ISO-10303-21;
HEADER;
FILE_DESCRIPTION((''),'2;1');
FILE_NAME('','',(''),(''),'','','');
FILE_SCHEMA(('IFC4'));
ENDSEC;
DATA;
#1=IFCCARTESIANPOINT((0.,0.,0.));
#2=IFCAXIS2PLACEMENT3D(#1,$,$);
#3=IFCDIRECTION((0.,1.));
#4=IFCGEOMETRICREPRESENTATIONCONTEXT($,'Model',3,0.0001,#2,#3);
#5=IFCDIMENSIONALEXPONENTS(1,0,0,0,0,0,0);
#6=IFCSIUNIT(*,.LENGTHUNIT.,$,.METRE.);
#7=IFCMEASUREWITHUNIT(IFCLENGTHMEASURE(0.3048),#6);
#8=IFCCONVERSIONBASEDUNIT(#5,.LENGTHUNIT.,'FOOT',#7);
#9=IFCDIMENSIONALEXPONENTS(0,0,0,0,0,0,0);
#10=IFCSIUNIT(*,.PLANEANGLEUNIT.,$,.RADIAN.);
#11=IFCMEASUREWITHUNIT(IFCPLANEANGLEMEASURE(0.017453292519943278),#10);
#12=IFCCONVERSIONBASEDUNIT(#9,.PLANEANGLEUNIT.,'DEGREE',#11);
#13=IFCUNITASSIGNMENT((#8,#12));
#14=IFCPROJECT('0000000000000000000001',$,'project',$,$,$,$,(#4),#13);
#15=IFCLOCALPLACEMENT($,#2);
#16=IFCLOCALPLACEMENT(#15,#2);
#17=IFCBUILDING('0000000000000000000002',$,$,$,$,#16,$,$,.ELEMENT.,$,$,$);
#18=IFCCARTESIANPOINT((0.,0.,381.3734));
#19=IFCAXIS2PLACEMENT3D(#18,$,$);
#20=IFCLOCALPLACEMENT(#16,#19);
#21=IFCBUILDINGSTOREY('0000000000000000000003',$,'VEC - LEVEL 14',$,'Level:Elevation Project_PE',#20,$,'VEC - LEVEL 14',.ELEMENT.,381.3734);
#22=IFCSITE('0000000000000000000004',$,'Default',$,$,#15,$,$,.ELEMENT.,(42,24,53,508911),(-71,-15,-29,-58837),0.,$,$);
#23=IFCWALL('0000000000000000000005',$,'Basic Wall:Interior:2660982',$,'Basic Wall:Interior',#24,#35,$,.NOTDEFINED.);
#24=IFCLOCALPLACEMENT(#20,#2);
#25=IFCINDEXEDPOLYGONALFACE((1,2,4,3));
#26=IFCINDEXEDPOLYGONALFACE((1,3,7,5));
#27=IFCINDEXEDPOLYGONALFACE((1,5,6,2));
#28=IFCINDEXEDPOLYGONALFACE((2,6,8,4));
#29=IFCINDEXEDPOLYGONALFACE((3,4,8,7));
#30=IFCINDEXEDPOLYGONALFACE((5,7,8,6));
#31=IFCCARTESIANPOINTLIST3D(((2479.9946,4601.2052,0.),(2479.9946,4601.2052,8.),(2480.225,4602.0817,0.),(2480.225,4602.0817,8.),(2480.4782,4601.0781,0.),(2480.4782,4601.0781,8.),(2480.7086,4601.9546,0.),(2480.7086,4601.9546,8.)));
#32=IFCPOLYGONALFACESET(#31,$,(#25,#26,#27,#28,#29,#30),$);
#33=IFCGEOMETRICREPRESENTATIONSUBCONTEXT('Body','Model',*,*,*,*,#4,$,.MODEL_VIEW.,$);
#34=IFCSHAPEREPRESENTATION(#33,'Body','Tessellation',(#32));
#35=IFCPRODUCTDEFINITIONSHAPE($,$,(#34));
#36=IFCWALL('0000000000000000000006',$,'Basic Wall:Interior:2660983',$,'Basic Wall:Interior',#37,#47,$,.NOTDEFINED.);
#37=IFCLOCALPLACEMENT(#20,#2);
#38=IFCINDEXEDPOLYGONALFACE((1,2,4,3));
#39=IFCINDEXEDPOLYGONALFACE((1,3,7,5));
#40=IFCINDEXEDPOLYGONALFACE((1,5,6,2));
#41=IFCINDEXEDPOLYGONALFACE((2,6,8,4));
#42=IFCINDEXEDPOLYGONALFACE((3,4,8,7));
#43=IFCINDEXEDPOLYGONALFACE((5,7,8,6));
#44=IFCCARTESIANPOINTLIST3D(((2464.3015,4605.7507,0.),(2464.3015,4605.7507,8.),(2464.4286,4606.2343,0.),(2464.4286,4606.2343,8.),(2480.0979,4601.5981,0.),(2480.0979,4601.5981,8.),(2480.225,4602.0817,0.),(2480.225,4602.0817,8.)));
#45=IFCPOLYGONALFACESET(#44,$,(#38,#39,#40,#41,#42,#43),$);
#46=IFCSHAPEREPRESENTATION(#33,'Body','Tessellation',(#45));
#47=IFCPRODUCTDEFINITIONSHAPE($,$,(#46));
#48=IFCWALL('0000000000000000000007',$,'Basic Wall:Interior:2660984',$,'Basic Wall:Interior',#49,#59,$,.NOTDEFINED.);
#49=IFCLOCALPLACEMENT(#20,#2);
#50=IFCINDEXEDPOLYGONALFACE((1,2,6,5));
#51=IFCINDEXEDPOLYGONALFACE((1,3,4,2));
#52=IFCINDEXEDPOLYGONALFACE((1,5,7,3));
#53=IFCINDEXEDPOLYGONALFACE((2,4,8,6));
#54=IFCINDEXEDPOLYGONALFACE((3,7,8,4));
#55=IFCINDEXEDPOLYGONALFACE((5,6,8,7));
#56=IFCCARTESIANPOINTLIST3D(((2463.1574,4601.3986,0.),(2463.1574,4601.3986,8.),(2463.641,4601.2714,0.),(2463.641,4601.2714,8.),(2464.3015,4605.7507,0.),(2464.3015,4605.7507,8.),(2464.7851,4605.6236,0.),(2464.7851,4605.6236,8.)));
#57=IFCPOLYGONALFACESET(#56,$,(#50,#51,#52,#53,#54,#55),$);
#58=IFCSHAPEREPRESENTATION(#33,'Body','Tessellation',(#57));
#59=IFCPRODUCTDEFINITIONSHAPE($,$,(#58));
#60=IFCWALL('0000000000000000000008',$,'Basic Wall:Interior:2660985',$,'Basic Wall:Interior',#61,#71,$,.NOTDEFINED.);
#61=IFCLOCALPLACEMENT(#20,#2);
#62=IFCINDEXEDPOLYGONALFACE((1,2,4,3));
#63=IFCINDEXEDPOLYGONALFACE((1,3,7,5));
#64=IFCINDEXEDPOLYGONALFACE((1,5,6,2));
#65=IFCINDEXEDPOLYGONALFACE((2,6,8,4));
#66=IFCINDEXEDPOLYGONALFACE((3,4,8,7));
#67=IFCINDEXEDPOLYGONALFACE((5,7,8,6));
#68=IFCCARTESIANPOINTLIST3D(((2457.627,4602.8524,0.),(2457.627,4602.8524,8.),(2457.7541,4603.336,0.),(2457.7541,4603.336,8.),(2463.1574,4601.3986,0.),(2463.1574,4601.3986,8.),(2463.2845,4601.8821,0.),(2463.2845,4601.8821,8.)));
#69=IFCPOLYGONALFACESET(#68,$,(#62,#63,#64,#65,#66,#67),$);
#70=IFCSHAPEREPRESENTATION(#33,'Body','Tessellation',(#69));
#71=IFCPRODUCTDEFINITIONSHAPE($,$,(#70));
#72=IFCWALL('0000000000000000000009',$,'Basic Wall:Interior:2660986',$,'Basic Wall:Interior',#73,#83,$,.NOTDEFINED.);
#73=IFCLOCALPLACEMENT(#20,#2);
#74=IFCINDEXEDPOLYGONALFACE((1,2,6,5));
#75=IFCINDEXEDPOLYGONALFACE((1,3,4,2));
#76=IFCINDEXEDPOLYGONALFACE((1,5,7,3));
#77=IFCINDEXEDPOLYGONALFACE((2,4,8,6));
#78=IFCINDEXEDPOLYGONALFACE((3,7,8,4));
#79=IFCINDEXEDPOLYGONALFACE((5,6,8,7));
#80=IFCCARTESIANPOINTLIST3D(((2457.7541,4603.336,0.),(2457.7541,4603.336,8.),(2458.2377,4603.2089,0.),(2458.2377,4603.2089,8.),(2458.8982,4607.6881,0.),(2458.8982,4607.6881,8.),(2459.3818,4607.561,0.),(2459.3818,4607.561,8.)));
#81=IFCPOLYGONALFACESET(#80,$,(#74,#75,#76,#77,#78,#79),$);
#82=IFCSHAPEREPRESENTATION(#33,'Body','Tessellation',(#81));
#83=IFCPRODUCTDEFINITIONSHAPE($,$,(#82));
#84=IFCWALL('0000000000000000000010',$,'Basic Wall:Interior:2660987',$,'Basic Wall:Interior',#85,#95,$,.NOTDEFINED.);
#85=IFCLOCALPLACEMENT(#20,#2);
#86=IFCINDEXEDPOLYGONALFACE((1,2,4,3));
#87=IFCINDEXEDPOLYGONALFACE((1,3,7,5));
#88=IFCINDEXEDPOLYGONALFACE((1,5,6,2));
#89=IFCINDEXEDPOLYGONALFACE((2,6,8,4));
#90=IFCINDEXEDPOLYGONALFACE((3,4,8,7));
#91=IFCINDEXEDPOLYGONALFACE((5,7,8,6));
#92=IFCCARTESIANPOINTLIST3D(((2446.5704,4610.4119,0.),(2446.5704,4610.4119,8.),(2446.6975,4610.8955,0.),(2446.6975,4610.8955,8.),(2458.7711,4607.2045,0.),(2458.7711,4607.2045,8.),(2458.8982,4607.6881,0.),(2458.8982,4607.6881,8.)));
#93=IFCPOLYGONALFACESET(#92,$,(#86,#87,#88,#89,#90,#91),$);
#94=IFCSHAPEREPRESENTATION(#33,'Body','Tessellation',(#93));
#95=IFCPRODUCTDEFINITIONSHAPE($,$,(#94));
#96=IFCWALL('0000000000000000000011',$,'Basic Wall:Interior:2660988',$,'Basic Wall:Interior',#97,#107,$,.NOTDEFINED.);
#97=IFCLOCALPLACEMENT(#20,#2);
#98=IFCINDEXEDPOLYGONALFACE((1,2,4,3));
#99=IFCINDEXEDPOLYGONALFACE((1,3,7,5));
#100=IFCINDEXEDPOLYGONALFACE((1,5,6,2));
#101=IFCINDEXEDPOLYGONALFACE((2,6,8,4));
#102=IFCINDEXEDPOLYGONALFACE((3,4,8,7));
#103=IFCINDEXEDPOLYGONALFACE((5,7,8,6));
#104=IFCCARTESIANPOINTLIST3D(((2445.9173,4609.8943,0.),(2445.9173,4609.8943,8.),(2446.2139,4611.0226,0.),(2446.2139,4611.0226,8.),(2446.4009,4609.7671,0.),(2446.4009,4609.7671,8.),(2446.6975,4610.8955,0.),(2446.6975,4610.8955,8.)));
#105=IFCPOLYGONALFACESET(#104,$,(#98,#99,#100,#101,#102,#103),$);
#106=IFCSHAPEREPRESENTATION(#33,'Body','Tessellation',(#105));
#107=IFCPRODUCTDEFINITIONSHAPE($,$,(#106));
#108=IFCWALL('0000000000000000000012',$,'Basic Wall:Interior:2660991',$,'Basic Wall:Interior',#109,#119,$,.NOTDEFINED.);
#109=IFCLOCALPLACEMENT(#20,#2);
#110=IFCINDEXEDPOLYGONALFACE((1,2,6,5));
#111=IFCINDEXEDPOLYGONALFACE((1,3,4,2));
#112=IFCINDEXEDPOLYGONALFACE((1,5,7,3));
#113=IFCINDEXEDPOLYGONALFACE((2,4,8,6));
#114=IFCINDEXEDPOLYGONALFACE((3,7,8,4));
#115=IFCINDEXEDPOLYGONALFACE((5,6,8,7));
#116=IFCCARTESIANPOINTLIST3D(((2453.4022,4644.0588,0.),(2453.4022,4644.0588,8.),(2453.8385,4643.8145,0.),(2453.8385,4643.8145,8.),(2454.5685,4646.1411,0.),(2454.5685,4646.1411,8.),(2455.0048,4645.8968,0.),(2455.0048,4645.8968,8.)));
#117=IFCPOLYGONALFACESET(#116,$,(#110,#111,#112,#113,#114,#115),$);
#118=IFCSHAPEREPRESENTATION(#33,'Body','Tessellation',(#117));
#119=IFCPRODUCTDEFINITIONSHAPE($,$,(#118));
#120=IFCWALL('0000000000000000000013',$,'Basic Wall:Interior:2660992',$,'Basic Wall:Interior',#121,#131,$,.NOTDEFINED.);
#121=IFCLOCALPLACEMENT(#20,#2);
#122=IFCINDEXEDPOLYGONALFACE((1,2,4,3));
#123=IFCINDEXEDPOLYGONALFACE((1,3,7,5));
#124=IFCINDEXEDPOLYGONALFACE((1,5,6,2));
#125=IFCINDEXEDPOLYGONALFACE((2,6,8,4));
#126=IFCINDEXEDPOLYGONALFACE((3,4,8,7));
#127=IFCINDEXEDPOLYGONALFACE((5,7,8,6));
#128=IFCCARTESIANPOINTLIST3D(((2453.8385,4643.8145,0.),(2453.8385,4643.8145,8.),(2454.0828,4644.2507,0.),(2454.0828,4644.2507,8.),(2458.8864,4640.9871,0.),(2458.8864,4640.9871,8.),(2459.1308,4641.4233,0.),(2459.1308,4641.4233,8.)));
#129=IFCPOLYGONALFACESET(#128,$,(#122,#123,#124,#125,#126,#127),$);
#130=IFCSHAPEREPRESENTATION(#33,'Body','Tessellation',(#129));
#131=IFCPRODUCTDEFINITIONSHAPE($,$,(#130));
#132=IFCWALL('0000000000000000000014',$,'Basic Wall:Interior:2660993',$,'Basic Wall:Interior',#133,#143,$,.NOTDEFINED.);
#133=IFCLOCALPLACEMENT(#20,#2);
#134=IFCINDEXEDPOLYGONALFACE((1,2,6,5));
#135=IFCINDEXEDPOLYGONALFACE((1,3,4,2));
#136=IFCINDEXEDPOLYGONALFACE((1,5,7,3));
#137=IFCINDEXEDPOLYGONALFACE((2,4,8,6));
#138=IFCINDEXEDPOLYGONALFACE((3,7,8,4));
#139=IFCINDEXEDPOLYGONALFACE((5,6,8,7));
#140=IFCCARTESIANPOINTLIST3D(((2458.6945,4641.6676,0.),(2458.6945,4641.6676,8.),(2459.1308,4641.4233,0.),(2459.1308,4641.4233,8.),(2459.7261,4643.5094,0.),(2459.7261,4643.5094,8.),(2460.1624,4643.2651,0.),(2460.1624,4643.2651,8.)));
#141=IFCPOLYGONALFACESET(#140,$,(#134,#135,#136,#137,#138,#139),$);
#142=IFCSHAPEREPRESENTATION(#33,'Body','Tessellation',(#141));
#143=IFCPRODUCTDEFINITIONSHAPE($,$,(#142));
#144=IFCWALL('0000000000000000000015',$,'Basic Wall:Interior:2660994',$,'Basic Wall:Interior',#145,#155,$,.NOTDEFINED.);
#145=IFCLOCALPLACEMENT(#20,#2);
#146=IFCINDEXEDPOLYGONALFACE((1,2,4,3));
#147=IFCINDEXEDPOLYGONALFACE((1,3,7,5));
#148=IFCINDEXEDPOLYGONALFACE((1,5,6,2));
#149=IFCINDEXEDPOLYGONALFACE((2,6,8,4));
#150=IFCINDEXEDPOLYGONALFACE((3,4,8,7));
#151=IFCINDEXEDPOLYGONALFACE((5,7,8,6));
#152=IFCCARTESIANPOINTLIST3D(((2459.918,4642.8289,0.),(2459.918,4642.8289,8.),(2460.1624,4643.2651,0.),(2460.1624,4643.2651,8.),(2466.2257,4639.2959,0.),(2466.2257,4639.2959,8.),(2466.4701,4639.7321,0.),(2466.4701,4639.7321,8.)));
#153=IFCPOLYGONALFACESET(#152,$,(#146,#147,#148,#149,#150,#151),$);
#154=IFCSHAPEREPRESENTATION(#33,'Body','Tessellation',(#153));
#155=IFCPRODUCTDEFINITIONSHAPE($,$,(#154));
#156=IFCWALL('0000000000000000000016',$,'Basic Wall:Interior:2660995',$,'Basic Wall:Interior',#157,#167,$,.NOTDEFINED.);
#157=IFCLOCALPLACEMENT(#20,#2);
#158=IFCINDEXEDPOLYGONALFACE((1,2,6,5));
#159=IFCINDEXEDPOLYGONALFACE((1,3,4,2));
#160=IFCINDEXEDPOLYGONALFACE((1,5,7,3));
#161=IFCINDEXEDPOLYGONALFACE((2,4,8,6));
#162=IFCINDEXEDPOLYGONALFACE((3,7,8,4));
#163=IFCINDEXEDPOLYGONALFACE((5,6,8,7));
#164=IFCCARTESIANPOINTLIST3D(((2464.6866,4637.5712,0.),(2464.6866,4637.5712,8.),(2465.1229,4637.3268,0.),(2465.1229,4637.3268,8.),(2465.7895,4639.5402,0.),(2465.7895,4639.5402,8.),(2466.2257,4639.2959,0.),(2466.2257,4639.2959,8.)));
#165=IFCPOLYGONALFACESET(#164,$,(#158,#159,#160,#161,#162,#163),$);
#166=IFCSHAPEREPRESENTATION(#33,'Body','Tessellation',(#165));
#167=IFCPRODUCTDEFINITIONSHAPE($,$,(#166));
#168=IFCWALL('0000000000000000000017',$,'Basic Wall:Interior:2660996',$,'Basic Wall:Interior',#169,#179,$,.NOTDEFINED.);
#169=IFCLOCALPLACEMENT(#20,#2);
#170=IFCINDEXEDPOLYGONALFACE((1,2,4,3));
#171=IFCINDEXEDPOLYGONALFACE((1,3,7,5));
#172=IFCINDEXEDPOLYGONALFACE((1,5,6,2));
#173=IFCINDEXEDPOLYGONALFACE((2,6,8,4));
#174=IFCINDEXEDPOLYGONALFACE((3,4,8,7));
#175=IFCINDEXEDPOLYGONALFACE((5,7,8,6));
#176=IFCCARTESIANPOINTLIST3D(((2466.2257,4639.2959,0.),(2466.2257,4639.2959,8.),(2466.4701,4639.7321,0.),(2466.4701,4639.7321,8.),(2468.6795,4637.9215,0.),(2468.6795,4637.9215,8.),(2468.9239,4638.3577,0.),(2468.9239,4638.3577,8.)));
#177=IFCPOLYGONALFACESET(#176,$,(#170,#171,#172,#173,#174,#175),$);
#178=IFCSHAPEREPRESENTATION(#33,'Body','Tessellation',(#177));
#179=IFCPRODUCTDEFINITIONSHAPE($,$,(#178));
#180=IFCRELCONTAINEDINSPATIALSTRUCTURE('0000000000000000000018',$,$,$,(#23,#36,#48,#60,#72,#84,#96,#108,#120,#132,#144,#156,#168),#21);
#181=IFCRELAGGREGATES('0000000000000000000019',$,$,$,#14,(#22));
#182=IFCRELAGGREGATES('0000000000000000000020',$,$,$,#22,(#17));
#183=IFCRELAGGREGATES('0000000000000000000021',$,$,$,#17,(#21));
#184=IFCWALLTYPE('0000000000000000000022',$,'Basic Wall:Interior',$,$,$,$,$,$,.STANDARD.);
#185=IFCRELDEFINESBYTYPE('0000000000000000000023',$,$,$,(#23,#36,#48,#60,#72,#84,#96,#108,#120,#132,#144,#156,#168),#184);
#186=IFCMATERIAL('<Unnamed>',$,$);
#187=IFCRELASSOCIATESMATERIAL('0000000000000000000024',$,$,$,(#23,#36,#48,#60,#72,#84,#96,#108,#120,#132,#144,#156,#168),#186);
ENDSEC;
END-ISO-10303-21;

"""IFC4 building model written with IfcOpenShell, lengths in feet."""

from ifc_helpers import new_model, entity, si_unit, converted_unit, direction, frame, origin, place, context, subcontext, project, spatial, indexed_curve, outline, extrude, material, type_object, element, save


model = new_model("IFC4")

# Units and contexts
model_context = context("Model", 3, precision=0.0001, world=origin(), true_north=direction((0.0, 1.0)))
body_context = subcontext(model_context, "Body", "Model", "MODEL_VIEW")
ifc_project = project(units=[converted_unit("LENGTHUNIT", "FOOT", entity("IfcLengthMeasure", 0.3048), si_unit("LENGTHUNIT", "METRE"), dimensions=[1, 0, 0, 0, 0, 0, 0]), converted_unit("PLANEANGLEUNIT", "DEGREE", entity("IfcPlaneAngleMeasure", 0.017453292519943278), si_unit("PLANEANGLEUNIT", "RADIAN"), dimensions=[0, 0, 0, 0, 0, 0, 0])], contexts=[model_context])

# Site, building, storey
site_placement = place(None, origin())
site = spatial("IfcSite", under=ifc_project, at=site_placement, Name="Default", CompositionType="ELEMENT", RefLatitude=(42, 24, 53, 508911), RefLongitude=(-71, -15, -29, -58837), RefElevation=0.0)
building_placement = place(site_placement, origin())
building = spatial("IfcBuilding", under=site, at=building_placement, CompositionType="ELEMENT")
storey_placement = place(building_placement, frame((0.0, 0.0, 381.3734)))
storey = spatial("IfcBuildingStorey", under=building, at=storey_placement, Name="VEC - LEVEL 14", ObjectType="Level:Elevation Project_PE", LongName="VEC - LEVEL 14", CompositionType="ELEMENT", Elevation=381.3734)

# Walls
ifc_material_1 = material(Name="<Unnamed>")
wall_type = type_object("IfcWallType", Name="Basic Wall:Interior", PredefinedType="STANDARD")
wall_1_placement = place(storey_placement, frame((2480.2364, 4601.1416, 0.0), z_axis=(0.0, 0.0, 1.0), x_axis=(0.254244, 0.96714, 0.0)))
element("IfcWall", 1, at=wall_1_placement, inside=storey, type_object=wall_type, material=ifc_material_1, Name="Basic Wall:Interior:2660982", ObjectType="Basic Wall:Interior", PredefinedType="NOTDEFINED", context=body_context, shape_type="SweptSolid", body=[
    extrude(outline(indexed_curve([(0.9062, 0.25), (0.0, 0.25), (0.0, -0.25), (0.9062, -0.25), (0.9062, 0.25)], self_intersect=False)), origin(), (0.0, 0.0, 1.0), 8.0),
])
wall_2_placement = place(storey_placement, frame((2480.1615, 4601.8399, 0.0), z_axis=(0.0, 0.0, 1.0), x_axis=(-0.96714, 0.254244, 0.0)))
element("IfcWall", 2, at=wall_2_placement, inside=storey, type_object=wall_type, material=ifc_material_1, Name="Basic Wall:Interior:2660983", ObjectType="Basic Wall:Interior", PredefinedType="NOTDEFINED", context=body_context, shape_type="SweptSolid", body=[
    extrude(outline(indexed_curve([(16.3331, 0.25), (0.0, 0.25), (0.0, -0.25), (16.3331, -0.25), (16.3331, 0.25)], self_intersect=False)), origin(), (0.0, 0.0, 1.0), 8.0),
])
wall_3_placement = place(storey_placement, frame((2464.5433, 4605.6871, 0.0), z_axis=(0.0, 0.0, 1.0), x_axis=(-0.254244, -0.96714, 0.0)))
element("IfcWall", 3, at=wall_3_placement, inside=storey, type_object=wall_type, material=ifc_material_1, Name="Basic Wall:Interior:2660984", ObjectType="Basic Wall:Interior", PredefinedType="NOTDEFINED", context=body_context, shape_type="SweptSolid", body=[
    extrude(outline(indexed_curve([(4.5, 0.25), (0.0, 0.25), (0.0, -0.25), (4.5, -0.25), (4.5, 0.25)], self_intersect=False)), origin(), (0.0, 0.0, 1.0), 8.0),
])
wall_4_placement = place(storey_placement, frame((2463.221, 4601.6404, 0.0), z_axis=(0.0, 0.0, 1.0), x_axis=(-0.96714, 0.254244, 0.0)))
element("IfcWall", 4, at=wall_4_placement, inside=storey, type_object=wall_type, material=ifc_material_1, Name="Basic Wall:Interior:2660985", ObjectType="Basic Wall:Interior", PredefinedType="NOTDEFINED", context=body_context, shape_type="SweptSolid", body=[
    extrude(outline(indexed_curve([(5.7183, 0.25), (0.0, 0.25), (0.0, -0.25), (5.7183, -0.25), (5.7183, 0.25)], self_intersect=False)), origin(), (0.0, 0.0, 1.0), 8.0),
])
wall_5_placement = place(storey_placement, frame((2457.9959, 4603.2724, 0.0), z_axis=(0.0, 0.0, 1.0), x_axis=(0.254244, 0.96714, 0.0)))
element("IfcWall", 5, at=wall_5_placement, inside=storey, type_object=wall_type, material=ifc_material_1, Name="Basic Wall:Interior:2660986", ObjectType="Basic Wall:Interior", PredefinedType="NOTDEFINED", context=body_context, shape_type="SweptSolid", body=[
    extrude(outline(indexed_curve([(4.5, 0.25), (0.0, 0.25), (0.0, -0.25), (4.5, -0.25), (4.5, 0.25)], self_intersect=False)), origin(), (0.0, 0.0, 1.0), 8.0),
])
wall_6_placement = place(storey_placement, frame((2458.8347, 4607.4463, 0.0), z_axis=(0.0, 0.0, 1.0), x_axis=(-0.96714, 0.254244, 0.0)))
element("IfcWall", 6, at=wall_6_placement, inside=storey, type_object=wall_type, material=ifc_material_1, Name="Basic Wall:Interior:2660987", ObjectType="Basic Wall:Interior", PredefinedType="NOTDEFINED", context=body_context, shape_type="SweptSolid", body=[
    extrude(outline(indexed_curve([(12.6153, 0.25), (0.0, 0.25), (0.0, -0.25), (12.6153, -0.25), (12.6153, 0.25)], self_intersect=False)), origin(), (0.0, 0.0, 1.0), 8.0),
])
wall_7_placement = place(storey_placement, frame((2446.4557, 4610.959, 0.0), z_axis=(0.0, 0.0, 1.0), x_axis=(-0.254244, -0.96714, 0.0)))
element("IfcWall", 7, at=wall_7_placement, inside=storey, type_object=wall_type, material=ifc_material_1, Name="Basic Wall:Interior:2660988", ObjectType="Basic Wall:Interior", PredefinedType="NOTDEFINED", context=body_context, shape_type="SweptSolid", body=[
    extrude(outline(indexed_curve([(1.1667, 0.25), (0.0, 0.25), (0.0, -0.25), (1.1667, -0.25), (1.1667, 0.25)], self_intersect=False)), origin(), (0.0, 0.0, 1.0), 8.0),
])
wall_8_placement = place(storey_placement, frame((2454.7866, 4646.0189, 0.0), z_axis=(0.0, 0.0, 1.0), x_axis=(-0.488675, -0.872466, 0.0)))
element("IfcWall", 8, at=wall_8_placement, inside=storey, type_object=wall_type, material=ifc_material_1, Name="Basic Wall:Interior:2660991", ObjectType="Basic Wall:Interior", PredefinedType="NOTDEFINED", context=body_context, shape_type="SweptSolid", body=[
    extrude(outline(indexed_curve([(2.3867, 0.25), (0.0, 0.25), (0.0, -0.25), (2.3867, -0.25), (2.3867, 0.25)], self_intersect=False)), origin(), (0.0, 0.0, 1.0), 8.0),
])
wall_9_placement = place(storey_placement, frame((2453.9606, 4644.0326, 0.0), z_axis=(0.0, 0.0, 1.0), x_axis=(0.872466, -0.488675, 0.0)))
element("IfcWall", 9, at=wall_9_placement, inside=storey, type_object=wall_type, material=ifc_material_1, Name="Basic Wall:Interior:2660992", ObjectType="Basic Wall:Interior", PredefinedType="NOTDEFINED", context=body_context, shape_type="SweptSolid", body=[
    extrude(outline(indexed_curve([(5.7859, 0.25), (0.0, 0.25), (0.0, -0.25), (5.7859, -0.25), (5.7859, 0.25)], self_intersect=False)), origin(), (0.0, 0.0, 1.0), 8.0),
])
wall_10_placement = place(storey_placement, frame((2458.9126, 4641.5455, 0.0), z_axis=(0.0, 0.0, 1.0), x_axis=(0.488675, 0.872466, 0.0)))
element("IfcWall", 10, at=wall_10_placement, inside=storey, type_object=wall_type, material=ifc_material_1, Name="Basic Wall:Interior:2660993", ObjectType="Basic Wall:Interior", PredefinedType="NOTDEFINED", context=body_context, shape_type="SweptSolid", body=[
    extrude(outline(indexed_curve([(2.111, 0.25), (0.0, 0.25), (0.0, -0.25), (2.111, -0.25), (2.111, 0.25)], self_intersect=False)), origin(), (0.0, 0.0, 1.0), 8.0),
])
wall_11_placement = place(storey_placement, frame((2460.0402, 4643.047, 0.0), z_axis=(0.0, 0.0, 1.0), x_axis=(0.872466, -0.488675, 0.0)))
element("IfcWall", 11, at=wall_11_placement, inside=storey, type_object=wall_type, material=ifc_material_1, Name="Basic Wall:Interior:2660994", ObjectType="Basic Wall:Interior", PredefinedType="NOTDEFINED", context=body_context, shape_type="SweptSolid", body=[
    extrude(outline(indexed_curve([(7.2297, 0.25), (0.0, 0.25), (0.0, -0.25), (7.2297, -0.25), (7.2297, 0.25)], self_intersect=False)), origin(), (0.0, 0.0, 1.0), 8.0),
])
wall_12_placement = place(storey_placement, frame((2466.0076, 4639.418, 0.0), z_axis=(0.0, 0.0, 1.0), x_axis=(-0.488675, -0.872466, 0.0)))
element("IfcWall", 12, at=wall_12_placement, inside=storey, type_object=wall_type, material=ifc_material_1, Name="Basic Wall:Interior:2660995", ObjectType="Basic Wall:Interior", PredefinedType="NOTDEFINED", context=body_context, shape_type="SweptSolid", body=[
    extrude(outline(indexed_curve([(2.2569, 0.25), (0.0, 0.25), (0.0, -0.25), (2.2569, -0.25), (2.2569, 0.25)], self_intersect=False)), origin(), (0.0, 0.0, 1.0), 8.0),
])
wall_13_placement = place(storey_placement, frame((2466.3479, 4639.514, 0.0), z_axis=(0.0, 0.0, 1.0), x_axis=(0.872466, -0.488675, 0.0)))
element("IfcWall", 13, at=wall_13_placement, inside=storey, type_object=wall_type, material=ifc_material_1, Name="Basic Wall:Interior:2660996", ObjectType="Basic Wall:Interior", PredefinedType="NOTDEFINED", context=body_context, shape_type="SweptSolid", body=[
    extrude(outline(indexed_curve([(2.8125, 0.25), (0.0, 0.25), (0.0, -0.25), (2.8125, -0.25), (2.8125, 0.25)], self_intersect=False)), origin(), (0.0, 0.0, 1.0), 8.0),
])

save(model, "model.ifc")
